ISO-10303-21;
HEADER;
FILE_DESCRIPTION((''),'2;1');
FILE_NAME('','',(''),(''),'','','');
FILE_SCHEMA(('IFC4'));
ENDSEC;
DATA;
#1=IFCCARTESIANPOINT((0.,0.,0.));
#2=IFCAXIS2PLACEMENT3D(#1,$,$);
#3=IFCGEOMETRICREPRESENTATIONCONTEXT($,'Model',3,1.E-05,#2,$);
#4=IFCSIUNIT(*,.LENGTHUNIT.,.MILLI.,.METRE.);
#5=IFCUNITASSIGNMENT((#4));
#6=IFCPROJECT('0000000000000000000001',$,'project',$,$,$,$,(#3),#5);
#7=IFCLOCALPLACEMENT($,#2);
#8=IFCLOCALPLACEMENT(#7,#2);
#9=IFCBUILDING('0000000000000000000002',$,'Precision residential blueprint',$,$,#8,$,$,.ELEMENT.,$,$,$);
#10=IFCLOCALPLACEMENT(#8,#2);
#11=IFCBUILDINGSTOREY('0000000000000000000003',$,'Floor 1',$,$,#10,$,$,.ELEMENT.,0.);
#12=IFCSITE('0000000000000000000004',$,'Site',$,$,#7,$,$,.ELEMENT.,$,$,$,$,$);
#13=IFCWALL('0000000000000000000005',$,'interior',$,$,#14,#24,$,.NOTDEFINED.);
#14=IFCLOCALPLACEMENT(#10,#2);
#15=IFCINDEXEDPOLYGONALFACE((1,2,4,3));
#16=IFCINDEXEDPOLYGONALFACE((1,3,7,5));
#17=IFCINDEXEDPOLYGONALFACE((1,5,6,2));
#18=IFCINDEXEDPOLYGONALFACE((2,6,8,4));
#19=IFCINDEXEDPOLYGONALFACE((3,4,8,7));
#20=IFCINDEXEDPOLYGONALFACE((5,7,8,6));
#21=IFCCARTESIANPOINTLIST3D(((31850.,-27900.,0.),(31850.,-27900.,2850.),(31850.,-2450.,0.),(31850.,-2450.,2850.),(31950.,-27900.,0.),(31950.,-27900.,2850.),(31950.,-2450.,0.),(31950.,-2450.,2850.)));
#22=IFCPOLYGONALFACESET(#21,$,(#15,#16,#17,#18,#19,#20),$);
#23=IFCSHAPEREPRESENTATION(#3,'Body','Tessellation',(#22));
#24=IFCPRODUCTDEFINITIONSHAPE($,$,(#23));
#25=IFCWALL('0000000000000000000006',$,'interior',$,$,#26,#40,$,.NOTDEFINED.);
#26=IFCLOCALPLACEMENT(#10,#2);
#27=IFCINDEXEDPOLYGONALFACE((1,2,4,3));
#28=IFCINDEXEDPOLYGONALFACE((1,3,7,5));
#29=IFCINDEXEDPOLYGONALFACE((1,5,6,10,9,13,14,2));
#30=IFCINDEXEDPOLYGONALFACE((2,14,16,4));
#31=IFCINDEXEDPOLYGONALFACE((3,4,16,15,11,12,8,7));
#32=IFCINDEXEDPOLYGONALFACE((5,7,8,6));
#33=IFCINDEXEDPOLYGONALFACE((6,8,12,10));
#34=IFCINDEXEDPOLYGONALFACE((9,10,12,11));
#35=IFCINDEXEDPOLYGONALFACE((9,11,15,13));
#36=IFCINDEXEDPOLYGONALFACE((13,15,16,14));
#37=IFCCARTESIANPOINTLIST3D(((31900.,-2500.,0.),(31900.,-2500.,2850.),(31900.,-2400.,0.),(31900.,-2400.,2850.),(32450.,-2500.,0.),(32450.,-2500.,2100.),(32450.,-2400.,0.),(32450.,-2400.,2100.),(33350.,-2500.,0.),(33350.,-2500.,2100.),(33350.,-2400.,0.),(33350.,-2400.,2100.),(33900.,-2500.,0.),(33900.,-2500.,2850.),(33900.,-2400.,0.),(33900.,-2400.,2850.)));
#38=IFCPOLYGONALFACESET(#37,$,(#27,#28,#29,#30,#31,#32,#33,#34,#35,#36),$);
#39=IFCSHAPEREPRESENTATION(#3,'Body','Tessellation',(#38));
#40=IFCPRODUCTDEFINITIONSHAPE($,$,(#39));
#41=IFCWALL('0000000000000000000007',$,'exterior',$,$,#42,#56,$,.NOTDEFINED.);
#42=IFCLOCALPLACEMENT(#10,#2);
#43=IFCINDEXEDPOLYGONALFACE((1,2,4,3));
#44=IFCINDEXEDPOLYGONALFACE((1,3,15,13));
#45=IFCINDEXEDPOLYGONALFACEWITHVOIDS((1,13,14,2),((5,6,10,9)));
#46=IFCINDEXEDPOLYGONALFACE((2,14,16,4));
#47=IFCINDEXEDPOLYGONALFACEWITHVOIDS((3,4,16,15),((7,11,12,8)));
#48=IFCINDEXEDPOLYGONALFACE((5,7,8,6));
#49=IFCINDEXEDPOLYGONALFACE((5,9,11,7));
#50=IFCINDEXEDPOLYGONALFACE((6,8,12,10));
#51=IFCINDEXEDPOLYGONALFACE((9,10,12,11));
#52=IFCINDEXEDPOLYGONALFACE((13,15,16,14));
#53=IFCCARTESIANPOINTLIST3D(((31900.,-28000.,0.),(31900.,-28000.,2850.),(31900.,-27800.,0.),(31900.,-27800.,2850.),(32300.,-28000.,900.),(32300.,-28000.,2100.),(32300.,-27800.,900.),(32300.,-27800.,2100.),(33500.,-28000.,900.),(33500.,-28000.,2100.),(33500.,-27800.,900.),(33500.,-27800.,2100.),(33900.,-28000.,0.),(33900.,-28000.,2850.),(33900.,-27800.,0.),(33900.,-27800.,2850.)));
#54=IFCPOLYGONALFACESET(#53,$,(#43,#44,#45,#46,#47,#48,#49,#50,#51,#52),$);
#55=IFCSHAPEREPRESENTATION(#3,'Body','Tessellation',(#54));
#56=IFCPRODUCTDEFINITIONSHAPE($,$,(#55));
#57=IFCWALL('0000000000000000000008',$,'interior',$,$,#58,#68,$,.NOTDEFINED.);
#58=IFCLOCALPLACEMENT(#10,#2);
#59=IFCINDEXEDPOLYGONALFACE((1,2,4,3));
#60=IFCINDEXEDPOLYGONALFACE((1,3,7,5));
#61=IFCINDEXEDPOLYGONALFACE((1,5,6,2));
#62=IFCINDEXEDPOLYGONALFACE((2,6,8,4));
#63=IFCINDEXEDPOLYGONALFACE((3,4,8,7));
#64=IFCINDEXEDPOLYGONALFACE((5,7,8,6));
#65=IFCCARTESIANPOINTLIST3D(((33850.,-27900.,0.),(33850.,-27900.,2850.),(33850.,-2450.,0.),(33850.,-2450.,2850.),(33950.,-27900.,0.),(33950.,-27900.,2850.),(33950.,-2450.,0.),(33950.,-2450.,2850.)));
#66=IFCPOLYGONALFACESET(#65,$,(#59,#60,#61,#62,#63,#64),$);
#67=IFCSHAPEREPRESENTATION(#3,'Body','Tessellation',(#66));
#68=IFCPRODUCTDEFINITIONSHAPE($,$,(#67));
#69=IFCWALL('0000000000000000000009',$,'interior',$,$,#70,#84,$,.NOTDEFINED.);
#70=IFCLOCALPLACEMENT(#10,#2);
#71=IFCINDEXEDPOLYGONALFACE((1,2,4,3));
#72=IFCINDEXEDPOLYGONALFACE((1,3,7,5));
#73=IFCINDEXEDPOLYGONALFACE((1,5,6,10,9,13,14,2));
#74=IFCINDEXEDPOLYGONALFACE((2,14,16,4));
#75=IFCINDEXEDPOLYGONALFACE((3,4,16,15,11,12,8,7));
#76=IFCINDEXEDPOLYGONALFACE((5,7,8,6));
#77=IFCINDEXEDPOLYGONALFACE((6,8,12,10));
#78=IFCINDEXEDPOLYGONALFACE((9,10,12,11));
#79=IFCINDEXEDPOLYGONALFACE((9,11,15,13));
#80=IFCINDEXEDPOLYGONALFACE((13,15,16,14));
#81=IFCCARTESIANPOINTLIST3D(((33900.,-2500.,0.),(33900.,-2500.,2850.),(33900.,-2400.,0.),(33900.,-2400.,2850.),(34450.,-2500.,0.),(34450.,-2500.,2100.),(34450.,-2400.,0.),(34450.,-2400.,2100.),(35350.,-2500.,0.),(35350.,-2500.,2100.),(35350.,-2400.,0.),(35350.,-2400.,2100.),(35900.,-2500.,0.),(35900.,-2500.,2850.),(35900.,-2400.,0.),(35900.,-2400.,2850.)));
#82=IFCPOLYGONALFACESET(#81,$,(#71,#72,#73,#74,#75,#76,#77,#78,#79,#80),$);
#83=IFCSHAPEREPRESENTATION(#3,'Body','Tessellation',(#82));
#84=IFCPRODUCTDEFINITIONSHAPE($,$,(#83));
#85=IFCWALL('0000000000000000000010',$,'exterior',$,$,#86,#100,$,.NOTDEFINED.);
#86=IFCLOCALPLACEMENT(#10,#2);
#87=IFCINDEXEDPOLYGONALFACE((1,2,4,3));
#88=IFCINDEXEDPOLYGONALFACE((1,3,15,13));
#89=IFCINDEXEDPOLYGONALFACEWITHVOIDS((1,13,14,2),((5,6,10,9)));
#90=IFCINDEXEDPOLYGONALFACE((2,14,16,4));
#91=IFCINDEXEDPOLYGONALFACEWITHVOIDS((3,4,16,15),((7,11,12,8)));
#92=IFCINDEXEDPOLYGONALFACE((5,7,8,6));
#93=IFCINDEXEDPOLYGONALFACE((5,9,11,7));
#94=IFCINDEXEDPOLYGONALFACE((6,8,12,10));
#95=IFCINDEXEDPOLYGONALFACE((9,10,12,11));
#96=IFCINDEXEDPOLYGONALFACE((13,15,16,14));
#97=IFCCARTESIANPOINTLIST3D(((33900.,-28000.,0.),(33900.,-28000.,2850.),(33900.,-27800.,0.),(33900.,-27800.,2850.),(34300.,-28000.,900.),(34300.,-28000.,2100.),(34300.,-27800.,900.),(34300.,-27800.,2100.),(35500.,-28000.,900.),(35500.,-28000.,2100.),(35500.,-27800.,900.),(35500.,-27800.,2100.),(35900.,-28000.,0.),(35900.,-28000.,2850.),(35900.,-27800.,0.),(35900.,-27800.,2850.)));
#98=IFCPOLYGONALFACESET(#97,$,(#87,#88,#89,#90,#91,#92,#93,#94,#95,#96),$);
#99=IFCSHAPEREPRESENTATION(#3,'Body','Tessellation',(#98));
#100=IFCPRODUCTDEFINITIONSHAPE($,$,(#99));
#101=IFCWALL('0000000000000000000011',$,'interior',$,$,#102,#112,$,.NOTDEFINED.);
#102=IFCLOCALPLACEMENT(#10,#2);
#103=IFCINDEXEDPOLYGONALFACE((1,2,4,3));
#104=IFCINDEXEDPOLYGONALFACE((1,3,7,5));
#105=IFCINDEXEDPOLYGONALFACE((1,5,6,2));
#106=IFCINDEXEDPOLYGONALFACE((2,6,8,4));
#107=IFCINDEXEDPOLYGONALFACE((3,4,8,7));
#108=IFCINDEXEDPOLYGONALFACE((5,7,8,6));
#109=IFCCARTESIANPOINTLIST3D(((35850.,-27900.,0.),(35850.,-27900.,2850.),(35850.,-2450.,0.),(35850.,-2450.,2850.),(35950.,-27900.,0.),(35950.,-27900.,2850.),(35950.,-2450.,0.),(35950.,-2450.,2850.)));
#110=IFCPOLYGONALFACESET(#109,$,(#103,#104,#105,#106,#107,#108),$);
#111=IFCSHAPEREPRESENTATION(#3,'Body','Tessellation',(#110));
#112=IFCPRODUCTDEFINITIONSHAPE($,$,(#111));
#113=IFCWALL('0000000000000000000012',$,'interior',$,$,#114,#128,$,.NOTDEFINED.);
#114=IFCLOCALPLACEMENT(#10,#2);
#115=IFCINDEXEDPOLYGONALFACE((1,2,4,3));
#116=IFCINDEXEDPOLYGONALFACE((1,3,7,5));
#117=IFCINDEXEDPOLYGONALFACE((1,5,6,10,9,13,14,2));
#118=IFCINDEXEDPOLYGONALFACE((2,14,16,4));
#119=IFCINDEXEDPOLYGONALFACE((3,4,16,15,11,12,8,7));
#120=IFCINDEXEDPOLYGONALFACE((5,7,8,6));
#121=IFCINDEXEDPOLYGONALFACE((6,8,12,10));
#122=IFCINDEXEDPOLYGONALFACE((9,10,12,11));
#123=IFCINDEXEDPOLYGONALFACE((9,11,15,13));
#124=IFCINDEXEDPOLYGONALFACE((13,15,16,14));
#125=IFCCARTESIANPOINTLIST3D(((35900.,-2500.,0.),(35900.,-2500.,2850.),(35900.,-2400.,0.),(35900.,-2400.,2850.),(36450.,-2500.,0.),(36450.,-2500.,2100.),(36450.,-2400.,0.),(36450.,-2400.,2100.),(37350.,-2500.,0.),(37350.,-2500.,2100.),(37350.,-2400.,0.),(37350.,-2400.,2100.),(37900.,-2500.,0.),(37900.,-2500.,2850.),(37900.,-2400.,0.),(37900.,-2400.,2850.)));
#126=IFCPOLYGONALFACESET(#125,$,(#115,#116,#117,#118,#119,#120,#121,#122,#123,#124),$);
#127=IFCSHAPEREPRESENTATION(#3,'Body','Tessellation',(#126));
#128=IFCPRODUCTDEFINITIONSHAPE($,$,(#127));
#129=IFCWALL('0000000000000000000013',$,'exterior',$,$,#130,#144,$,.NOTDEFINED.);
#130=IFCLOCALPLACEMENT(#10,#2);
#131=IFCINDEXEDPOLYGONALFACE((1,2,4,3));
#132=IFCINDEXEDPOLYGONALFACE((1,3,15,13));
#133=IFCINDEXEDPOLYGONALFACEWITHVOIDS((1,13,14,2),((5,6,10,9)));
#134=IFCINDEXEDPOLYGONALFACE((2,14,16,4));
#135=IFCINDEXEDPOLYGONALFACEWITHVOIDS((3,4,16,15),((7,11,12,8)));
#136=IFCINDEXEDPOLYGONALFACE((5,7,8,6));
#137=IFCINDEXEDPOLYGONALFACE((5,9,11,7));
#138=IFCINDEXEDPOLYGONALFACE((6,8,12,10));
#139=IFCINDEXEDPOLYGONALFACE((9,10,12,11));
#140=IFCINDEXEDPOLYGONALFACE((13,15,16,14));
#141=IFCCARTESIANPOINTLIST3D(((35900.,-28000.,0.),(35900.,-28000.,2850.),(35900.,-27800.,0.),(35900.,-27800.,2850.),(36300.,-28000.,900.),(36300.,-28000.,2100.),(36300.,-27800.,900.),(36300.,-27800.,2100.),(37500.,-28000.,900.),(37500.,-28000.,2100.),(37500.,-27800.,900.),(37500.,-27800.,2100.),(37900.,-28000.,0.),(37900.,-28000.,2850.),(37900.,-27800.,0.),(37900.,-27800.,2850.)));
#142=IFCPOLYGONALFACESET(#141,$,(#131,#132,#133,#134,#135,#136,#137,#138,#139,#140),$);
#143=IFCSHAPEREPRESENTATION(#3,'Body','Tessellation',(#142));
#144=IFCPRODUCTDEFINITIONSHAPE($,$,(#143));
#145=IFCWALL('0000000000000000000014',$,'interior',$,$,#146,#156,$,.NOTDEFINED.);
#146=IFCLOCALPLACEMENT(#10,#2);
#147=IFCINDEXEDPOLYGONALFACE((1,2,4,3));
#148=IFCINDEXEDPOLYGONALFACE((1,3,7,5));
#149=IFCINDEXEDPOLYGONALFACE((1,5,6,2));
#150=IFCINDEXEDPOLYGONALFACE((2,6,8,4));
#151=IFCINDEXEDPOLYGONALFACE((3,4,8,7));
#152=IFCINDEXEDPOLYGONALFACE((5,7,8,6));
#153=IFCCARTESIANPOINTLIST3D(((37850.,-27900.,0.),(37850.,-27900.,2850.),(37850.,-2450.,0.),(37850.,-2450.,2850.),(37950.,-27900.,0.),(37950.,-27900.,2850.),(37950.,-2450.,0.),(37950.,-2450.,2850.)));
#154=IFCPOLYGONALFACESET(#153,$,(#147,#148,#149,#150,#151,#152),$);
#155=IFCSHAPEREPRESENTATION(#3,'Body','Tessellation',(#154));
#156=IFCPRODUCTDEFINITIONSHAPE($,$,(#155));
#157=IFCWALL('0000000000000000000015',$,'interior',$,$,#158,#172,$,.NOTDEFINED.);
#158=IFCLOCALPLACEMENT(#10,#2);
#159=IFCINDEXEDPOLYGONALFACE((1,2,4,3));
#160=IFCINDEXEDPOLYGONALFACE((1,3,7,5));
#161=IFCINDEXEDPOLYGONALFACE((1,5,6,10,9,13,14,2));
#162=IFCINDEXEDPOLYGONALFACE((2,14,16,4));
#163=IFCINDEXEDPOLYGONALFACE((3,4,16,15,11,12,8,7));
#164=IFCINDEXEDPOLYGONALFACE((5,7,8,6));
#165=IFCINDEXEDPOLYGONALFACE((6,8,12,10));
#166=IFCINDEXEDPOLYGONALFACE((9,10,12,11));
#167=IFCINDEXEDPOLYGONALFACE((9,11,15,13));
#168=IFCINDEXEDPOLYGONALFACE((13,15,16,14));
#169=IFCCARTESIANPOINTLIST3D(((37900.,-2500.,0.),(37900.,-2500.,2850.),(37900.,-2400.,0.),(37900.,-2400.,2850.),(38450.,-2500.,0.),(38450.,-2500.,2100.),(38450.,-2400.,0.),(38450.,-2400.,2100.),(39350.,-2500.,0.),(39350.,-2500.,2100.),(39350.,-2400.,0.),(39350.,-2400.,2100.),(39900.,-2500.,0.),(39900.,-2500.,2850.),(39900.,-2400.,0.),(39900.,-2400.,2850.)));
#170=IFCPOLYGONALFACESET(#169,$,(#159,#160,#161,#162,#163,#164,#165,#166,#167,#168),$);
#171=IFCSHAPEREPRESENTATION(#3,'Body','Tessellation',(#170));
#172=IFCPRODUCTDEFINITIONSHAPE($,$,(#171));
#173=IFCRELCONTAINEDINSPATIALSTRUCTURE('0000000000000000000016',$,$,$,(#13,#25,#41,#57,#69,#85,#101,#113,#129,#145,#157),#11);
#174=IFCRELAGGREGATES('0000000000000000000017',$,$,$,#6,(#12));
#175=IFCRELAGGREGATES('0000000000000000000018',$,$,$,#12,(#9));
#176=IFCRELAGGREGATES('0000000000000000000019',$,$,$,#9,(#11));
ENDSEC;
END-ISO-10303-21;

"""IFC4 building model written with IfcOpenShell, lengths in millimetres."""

from ifc_helpers import new_model, si_unit, frame, origin, place, context, project, spatial, polyline, outline, extrude, element, save


model = new_model("IFC4")

# Units and contexts
model_context = context("Model", 3, precision=1e-05, world=origin())
ifc_project = project(units=[si_unit("LENGTHUNIT", "METRE", prefix="MILLI")], contexts=[model_context])

# Site, building, storey
site_placement = place(None, origin())
site = spatial("IfcSite", under=ifc_project, at=site_placement, Name="Site", CompositionType="ELEMENT")
building_placement = place(site_placement, origin())
building = spatial("IfcBuilding", under=site, at=building_placement, Name="Precision residential blueprint", CompositionType="ELEMENT")
storey_placement = place(building_placement, origin())
storey = spatial("IfcBuildingStorey", under=building, at=storey_placement, Name="Floor 1", CompositionType="ELEMENT", Elevation=0.0)

# Wall
wall_1_placement = place(storey_placement, origin())
element("IfcWall", 1, at=wall_1_placement, inside=storey, Name="interior", PredefinedType="NOTDEFINED", context=model_context, shape_type="SweptSolid", body=[
    extrude(outline(polyline([(31950.0, -2450.0), (31950.0, -27900.0), (31850.0, -27900.0), (31850.0, -2450.0), (31950.0, -2450.0)])), origin(), (0.0, 0.0, 1.0), 2850.0),
])

# Walls, openings
wall_2_placement = place(storey_placement, origin())
wall_2 = element("IfcWall", 2, at=wall_2_placement, inside=storey, Name="interior", PredefinedType="NOTDEFINED", context=model_context, shape_type="SweptSolid", body=[
    extrude(outline(polyline([(31900.0, -2400.0), (33900.0, -2400.0), (33900.0, -2500.0), (31900.0, -2500.0), (31900.0, -2400.0)])), origin(), (0.0, 0.0, 1.0), 2850.0),
])
opening_1_placement = place(storey_placement, origin())
element("IfcOpeningElement", 3, at=opening_1_placement, cuts=wall_2, PredefinedType="OPENING", context=model_context, shape_type="SweptSolid", body=[
    extrude(outline(polyline([(32450.0, -2400.0), (33350.0, -2400.0), (33350.0, -2500.0), (32450.0, -2500.0), (32450.0, -2400.0)])), origin(), (0.0, 0.0, 1.0), 2100.0),
])
wall_3_placement = place(storey_placement, origin())
wall_3 = element("IfcWall", 4, at=wall_3_placement, inside=storey, Name="exterior", PredefinedType="NOTDEFINED", context=model_context, shape_type="SweptSolid", body=[
    extrude(outline(polyline([(31900.0, -27800.0), (33900.0, -27800.0), (33900.0, -28000.0), (31900.0, -28000.0), (31900.0, -27800.0)])), origin(), (0.0, 0.0, 1.0), 2850.0),
])
opening_2_placement = place(storey_placement, origin())
element("IfcOpeningElement", 5, at=opening_2_placement, cuts=wall_3, PredefinedType="OPENING", context=model_context, shape_type="SweptSolid", body=[
    extrude(outline(polyline([(32300.0, -27800.0), (33500.0, -27800.0), (33500.0, -28000.0), (32300.0, -28000.0), (32300.0, -27800.0)])), frame((0.0, 0.0, 900.0)), (0.0, 0.0, 1.0), 1200.0),
])

# Wall
wall_4_placement = place(storey_placement, origin())
element("IfcWall", 6, at=wall_4_placement, inside=storey, Name="interior", PredefinedType="NOTDEFINED", context=model_context, shape_type="SweptSolid", body=[
    extrude(outline(polyline([(33950.0, -2450.0), (33950.0, -27900.0), (33850.0, -27900.0), (33850.0, -2450.0), (33950.0, -2450.0)])), origin(), (0.0, 0.0, 1.0), 2850.0),
])

# Walls, openings
wall_5_placement = place(storey_placement, origin())
wall_5 = element("IfcWall", 7, at=wall_5_placement, inside=storey, Name="interior", PredefinedType="NOTDEFINED", context=model_context, shape_type="SweptSolid", body=[
    extrude(outline(polyline([(33900.0, -2400.0), (35900.0, -2400.0), (35900.0, -2500.0), (33900.0, -2500.0), (33900.0, -2400.0)])), origin(), (0.0, 0.0, 1.0), 2850.0),
])
opening_3_placement = place(storey_placement, origin())
element("IfcOpeningElement", 8, at=opening_3_placement, cuts=wall_5, PredefinedType="OPENING", context=model_context, shape_type="SweptSolid", body=[
    extrude(outline(polyline([(34450.0, -2400.0), (35350.0, -2400.0), (35350.0, -2500.0), (34450.0, -2500.0), (34450.0, -2400.0)])), origin(), (0.0, 0.0, 1.0), 2100.0),
])
wall_6_placement = place(storey_placement, origin())
wall_6 = element("IfcWall", 9, at=wall_6_placement, inside=storey, Name="exterior", PredefinedType="NOTDEFINED", context=model_context, shape_type="SweptSolid", body=[
    extrude(outline(polyline([(33900.0, -27800.0), (35900.0, -27800.0), (35900.0, -28000.0), (33900.0, -28000.0), (33900.0, -27800.0)])), origin(), (0.0, 0.0, 1.0), 2850.0),
])
opening_4_placement = place(storey_placement, origin())
element("IfcOpeningElement", 10, at=opening_4_placement, cuts=wall_6, PredefinedType="OPENING", context=model_context, shape_type="SweptSolid", body=[
    extrude(outline(polyline([(34300.0, -27800.0), (35500.0, -27800.0), (35500.0, -28000.0), (34300.0, -28000.0), (34300.0, -27800.0)])), frame((0.0, 0.0, 900.0)), (0.0, 0.0, 1.0), 1200.0),
])

# Wall
wall_7_placement = place(storey_placement, origin())
element("IfcWall", 11, at=wall_7_placement, inside=storey, Name="interior", PredefinedType="NOTDEFINED", context=model_context, shape_type="SweptSolid", body=[
    extrude(outline(polyline([(35950.0, -2450.0), (35950.0, -27900.0), (35850.0, -27900.0), (35850.0, -2450.0), (35950.0, -2450.0)])), origin(), (0.0, 0.0, 1.0), 2850.0),
])

# Walls, openings
wall_8_placement = place(storey_placement, origin())
wall_8 = element("IfcWall", 12, at=wall_8_placement, inside=storey, Name="interior", PredefinedType="NOTDEFINED", context=model_context, shape_type="SweptSolid", body=[
    extrude(outline(polyline([(35900.0, -2400.0), (37900.0, -2400.0), (37900.0, -2500.0), (35900.0, -2500.0), (35900.0, -2400.0)])), origin(), (0.0, 0.0, 1.0), 2850.0),
])
opening_5_placement = place(storey_placement, origin())
element("IfcOpeningElement", 13, at=opening_5_placement, cuts=wall_8, PredefinedType="OPENING", context=model_context, shape_type="SweptSolid", body=[
    extrude(outline(polyline([(36450.0, -2400.0), (37350.0, -2400.0), (37350.0, -2500.0), (36450.0, -2500.0), (36450.0, -2400.0)])), origin(), (0.0, 0.0, 1.0), 2100.0),
])
wall_9_placement = place(storey_placement, origin())
wall_9 = element("IfcWall", 14, at=wall_9_placement, inside=storey, Name="exterior", PredefinedType="NOTDEFINED", context=model_context, shape_type="SweptSolid", body=[
    extrude(outline(polyline([(35900.0, -27800.0), (37900.0, -27800.0), (37900.0, -28000.0), (35900.0, -28000.0), (35900.0, -27800.0)])), origin(), (0.0, 0.0, 1.0), 2850.0),
])
opening_6_placement = place(storey_placement, origin())
element("IfcOpeningElement", 15, at=opening_6_placement, cuts=wall_9, PredefinedType="OPENING", context=model_context, shape_type="SweptSolid", body=[
    extrude(outline(polyline([(36300.0, -27800.0), (37500.0, -27800.0), (37500.0, -28000.0), (36300.0, -28000.0), (36300.0, -27800.0)])), frame((0.0, 0.0, 900.0)), (0.0, 0.0, 1.0), 1200.0),
])

# Wall
wall_10_placement = place(storey_placement, origin())
element("IfcWall", 16, at=wall_10_placement, inside=storey, Name="interior", PredefinedType="NOTDEFINED", context=model_context, shape_type="SweptSolid", body=[
    extrude(outline(polyline([(37950.0, -2450.0), (37950.0, -27900.0), (37850.0, -27900.0), (37850.0, -2450.0), (37950.0, -2450.0)])), origin(), (0.0, 0.0, 1.0), 2850.0),
])

# Wall, opening
wall_11_placement = place(storey_placement, origin())
wall_11 = element("IfcWall", 17, at=wall_11_placement, inside=storey, Name="interior", PredefinedType="NOTDEFINED", context=model_context, shape_type="SweptSolid", body=[
    extrude(outline(polyline([(37900.0, -2400.0), (39900.0, -2400.0), (39900.0, -2500.0), (37900.0, -2500.0), (37900.0, -2400.0)])), origin(), (0.0, 0.0, 1.0), 2850.0),
])
opening_7_placement = place(storey_placement, origin())
element("IfcOpeningElement", 18, at=opening_7_placement, cuts=wall_11, PredefinedType="OPENING", context=model_context, shape_type="SweptSolid", body=[
    extrude(outline(polyline([(38450.0, -2400.0), (39350.0, -2400.0), (39350.0, -2500.0), (38450.0, -2500.0), (38450.0, -2400.0)])), origin(), (0.0, 0.0, 1.0), 2100.0),
])

save(model, "model.ifc")
